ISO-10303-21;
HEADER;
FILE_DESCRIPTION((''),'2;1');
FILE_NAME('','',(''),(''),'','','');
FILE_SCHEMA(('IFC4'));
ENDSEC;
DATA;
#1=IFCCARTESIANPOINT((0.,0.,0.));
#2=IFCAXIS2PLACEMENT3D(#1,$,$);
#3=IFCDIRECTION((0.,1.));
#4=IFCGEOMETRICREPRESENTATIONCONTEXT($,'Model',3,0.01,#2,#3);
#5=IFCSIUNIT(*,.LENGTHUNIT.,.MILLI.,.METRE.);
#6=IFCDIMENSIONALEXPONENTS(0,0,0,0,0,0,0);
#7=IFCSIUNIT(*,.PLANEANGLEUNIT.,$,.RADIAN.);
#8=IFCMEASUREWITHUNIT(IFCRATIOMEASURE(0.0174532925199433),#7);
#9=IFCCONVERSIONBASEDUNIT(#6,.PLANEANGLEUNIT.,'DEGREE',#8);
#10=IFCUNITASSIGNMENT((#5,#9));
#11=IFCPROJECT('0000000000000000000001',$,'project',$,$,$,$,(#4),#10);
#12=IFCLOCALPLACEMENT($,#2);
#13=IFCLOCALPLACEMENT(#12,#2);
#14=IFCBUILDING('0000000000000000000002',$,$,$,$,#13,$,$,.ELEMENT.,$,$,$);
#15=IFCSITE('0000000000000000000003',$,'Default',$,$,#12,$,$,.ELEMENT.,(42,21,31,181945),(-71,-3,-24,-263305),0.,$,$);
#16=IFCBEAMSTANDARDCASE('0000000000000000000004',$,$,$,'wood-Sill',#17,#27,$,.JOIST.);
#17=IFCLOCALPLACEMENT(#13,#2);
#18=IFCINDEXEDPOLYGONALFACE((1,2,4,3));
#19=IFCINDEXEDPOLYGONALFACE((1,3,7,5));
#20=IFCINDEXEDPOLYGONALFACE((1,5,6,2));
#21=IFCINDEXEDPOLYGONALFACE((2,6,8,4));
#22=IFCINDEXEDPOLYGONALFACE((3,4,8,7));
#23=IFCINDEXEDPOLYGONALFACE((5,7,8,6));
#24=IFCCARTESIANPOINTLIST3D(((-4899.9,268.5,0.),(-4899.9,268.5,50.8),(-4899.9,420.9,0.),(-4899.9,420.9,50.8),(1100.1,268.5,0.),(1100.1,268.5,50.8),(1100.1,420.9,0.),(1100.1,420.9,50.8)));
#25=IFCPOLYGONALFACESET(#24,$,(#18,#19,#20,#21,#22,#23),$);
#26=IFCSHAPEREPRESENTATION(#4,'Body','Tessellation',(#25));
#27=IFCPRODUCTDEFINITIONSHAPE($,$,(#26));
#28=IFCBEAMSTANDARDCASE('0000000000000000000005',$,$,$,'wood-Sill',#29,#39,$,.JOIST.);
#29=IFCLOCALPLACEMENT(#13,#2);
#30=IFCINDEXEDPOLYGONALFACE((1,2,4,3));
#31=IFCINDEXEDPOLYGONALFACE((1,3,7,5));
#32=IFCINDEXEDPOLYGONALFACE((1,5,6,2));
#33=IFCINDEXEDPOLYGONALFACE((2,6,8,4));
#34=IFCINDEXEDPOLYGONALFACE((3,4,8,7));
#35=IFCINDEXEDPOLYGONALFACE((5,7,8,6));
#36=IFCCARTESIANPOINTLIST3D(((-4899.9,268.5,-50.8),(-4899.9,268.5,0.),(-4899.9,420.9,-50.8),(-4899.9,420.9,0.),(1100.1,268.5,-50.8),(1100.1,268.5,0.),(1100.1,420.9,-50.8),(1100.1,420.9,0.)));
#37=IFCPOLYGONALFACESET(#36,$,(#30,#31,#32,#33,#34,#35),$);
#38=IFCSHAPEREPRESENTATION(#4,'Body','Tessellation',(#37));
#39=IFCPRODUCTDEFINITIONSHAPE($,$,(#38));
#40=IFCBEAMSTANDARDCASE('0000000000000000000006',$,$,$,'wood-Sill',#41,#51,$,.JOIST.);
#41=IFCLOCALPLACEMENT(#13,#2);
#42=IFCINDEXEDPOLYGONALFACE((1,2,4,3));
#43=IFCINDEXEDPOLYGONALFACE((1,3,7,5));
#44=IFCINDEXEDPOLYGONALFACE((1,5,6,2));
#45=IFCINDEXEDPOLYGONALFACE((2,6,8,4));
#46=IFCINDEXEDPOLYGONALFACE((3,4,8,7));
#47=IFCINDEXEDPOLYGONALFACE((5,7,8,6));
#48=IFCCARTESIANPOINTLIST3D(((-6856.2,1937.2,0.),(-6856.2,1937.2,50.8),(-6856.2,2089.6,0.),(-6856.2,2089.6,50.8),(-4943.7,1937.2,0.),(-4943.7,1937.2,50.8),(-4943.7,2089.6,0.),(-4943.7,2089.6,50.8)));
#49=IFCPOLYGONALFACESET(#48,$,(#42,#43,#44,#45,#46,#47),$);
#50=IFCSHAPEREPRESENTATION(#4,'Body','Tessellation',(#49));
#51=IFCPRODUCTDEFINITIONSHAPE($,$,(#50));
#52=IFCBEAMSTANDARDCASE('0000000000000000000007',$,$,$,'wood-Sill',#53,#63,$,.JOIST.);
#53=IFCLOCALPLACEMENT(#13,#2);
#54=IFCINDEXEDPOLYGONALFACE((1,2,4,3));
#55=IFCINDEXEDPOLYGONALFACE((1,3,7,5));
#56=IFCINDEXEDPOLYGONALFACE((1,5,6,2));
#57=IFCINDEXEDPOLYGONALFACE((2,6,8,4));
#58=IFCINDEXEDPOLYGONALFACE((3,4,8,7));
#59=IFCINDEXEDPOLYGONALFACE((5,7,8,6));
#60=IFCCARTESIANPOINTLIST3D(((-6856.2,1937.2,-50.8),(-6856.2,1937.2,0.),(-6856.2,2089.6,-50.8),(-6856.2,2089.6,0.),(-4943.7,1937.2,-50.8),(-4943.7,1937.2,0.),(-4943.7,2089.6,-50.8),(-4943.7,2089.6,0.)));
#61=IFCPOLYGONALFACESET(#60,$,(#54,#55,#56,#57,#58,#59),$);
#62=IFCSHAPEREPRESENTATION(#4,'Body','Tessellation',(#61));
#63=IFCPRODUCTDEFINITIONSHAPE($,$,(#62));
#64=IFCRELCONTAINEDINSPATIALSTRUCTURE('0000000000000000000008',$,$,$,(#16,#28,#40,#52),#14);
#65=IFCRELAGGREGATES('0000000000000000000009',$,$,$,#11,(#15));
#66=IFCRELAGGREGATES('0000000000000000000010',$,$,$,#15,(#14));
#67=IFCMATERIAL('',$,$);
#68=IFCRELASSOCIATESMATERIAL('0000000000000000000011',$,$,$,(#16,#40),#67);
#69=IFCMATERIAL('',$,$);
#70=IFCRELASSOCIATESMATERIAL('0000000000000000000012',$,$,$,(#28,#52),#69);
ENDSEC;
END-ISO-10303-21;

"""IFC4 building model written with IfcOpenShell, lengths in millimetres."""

from ifc_helpers import new_model, entity, si_unit, converted_unit, direction, frame, origin, place, context, project, spatial, rectangle, extrude, material, element, save


model = new_model("IFC4")

# Units and contexts
model_context = context("Model", 3, precision=0.01, world=origin(), true_north=direction((0.0, 1.0)))
ifc_project = project(units=[si_unit("LENGTHUNIT", "METRE", prefix="MILLI"), converted_unit("PLANEANGLEUNIT", "DEGREE", entity("IfcRatioMeasure", 0.0174532925199433), si_unit("PLANEANGLEUNIT", "RADIAN"), dimensions=[0, 0, 0, 0, 0, 0, 0])], contexts=[model_context])

# Site, building
site_placement = place(None, origin())
site = spatial("IfcSite", under=ifc_project, at=site_placement, Name="Default", CompositionType="ELEMENT", RefLatitude=(42, 21, 31, 181945), RefLongitude=(-71, -3, -24, -263305), RefElevation=0.0)
building_placement = place(site_placement, origin())
building = spatial("IfcBuilding", under=site, at=building_placement, CompositionType="ELEMENT")

# Shared definitions
placement_1 = place(building_placement, origin())
placement_2 = place(placement_1, frame((-1899.9, -2655.3, 0.0), z_axis=(0.0, 0.0, 1.0), x_axis=(0.0, 1.0, 0.0)))
placement_3 = place(placement_1, frame((-5899.9, 1057.2, 0.0), z_axis=(0.0, 0.0, 1.0), x_axis=(0.0, 1.0, 0.0)))

# Beams
ifc_material_1 = material(Name="")
beam_1_placement = place(placement_2, frame((3000.0, 0.0, 0.0), z_axis=(0.0, 0.0, 1.0), x_axis=(0.0, 1.0, 0.0)))
element("IfcBeamStandardCase", 1, at=beam_1_placement, inside=building, material=ifc_material_1, ObjectType="wood-Sill", PredefinedType="JOIST", context=model_context, shape_type="SweptSolid", body=[
    extrude(rectangle(XDim=6000.0, YDim=152.4), origin(), (0.0, 0.0, 1.0), 50.8),
])
ifc_material_2 = material(Name="")
beam_2_placement = place(placement_2, frame((3000.0, 0.0, -50.8), z_axis=(0.0, 0.0, 1.0), x_axis=(0.0, 1.0, 0.0)))
element("IfcBeamStandardCase", 2, at=beam_2_placement, inside=building, material=ifc_material_2, ObjectType="wood-Sill", PredefinedType="JOIST", context=model_context, shape_type="SweptSolid", body=[
    extrude(rectangle(XDim=6000.0, YDim=152.4), origin(), (0.0, 0.0, 1.0), 50.8),
])
beam_3_placement = place(placement_3, frame((956.2, 0.0, 0.0), z_axis=(0.0, 0.0, 1.0), x_axis=(0.0, 1.0, 0.0)))
element("IfcBeamStandardCase", 3, at=beam_3_placement, inside=building, material=ifc_material_1, ObjectType="wood-Sill", PredefinedType="JOIST", context=model_context, shape_type="SweptSolid", body=[
    extrude(rectangle(XDim=1912.5, YDim=152.4), origin(), (0.0, 0.0, 1.0), 50.8),
])
beam_4_placement = place(placement_3, frame((956.2, 0.0, -50.8), z_axis=(0.0, 0.0, 1.0), x_axis=(0.0, 1.0, 0.0)))
element("IfcBeamStandardCase", 4, at=beam_4_placement, inside=building, material=ifc_material_2, ObjectType="wood-Sill", PredefinedType="JOIST", context=model_context, shape_type="SweptSolid", body=[
    extrude(rectangle(XDim=1912.5, YDim=152.4), origin(), (0.0, 0.0, 1.0), 50.8),
])

save(model, "model.ifc")
